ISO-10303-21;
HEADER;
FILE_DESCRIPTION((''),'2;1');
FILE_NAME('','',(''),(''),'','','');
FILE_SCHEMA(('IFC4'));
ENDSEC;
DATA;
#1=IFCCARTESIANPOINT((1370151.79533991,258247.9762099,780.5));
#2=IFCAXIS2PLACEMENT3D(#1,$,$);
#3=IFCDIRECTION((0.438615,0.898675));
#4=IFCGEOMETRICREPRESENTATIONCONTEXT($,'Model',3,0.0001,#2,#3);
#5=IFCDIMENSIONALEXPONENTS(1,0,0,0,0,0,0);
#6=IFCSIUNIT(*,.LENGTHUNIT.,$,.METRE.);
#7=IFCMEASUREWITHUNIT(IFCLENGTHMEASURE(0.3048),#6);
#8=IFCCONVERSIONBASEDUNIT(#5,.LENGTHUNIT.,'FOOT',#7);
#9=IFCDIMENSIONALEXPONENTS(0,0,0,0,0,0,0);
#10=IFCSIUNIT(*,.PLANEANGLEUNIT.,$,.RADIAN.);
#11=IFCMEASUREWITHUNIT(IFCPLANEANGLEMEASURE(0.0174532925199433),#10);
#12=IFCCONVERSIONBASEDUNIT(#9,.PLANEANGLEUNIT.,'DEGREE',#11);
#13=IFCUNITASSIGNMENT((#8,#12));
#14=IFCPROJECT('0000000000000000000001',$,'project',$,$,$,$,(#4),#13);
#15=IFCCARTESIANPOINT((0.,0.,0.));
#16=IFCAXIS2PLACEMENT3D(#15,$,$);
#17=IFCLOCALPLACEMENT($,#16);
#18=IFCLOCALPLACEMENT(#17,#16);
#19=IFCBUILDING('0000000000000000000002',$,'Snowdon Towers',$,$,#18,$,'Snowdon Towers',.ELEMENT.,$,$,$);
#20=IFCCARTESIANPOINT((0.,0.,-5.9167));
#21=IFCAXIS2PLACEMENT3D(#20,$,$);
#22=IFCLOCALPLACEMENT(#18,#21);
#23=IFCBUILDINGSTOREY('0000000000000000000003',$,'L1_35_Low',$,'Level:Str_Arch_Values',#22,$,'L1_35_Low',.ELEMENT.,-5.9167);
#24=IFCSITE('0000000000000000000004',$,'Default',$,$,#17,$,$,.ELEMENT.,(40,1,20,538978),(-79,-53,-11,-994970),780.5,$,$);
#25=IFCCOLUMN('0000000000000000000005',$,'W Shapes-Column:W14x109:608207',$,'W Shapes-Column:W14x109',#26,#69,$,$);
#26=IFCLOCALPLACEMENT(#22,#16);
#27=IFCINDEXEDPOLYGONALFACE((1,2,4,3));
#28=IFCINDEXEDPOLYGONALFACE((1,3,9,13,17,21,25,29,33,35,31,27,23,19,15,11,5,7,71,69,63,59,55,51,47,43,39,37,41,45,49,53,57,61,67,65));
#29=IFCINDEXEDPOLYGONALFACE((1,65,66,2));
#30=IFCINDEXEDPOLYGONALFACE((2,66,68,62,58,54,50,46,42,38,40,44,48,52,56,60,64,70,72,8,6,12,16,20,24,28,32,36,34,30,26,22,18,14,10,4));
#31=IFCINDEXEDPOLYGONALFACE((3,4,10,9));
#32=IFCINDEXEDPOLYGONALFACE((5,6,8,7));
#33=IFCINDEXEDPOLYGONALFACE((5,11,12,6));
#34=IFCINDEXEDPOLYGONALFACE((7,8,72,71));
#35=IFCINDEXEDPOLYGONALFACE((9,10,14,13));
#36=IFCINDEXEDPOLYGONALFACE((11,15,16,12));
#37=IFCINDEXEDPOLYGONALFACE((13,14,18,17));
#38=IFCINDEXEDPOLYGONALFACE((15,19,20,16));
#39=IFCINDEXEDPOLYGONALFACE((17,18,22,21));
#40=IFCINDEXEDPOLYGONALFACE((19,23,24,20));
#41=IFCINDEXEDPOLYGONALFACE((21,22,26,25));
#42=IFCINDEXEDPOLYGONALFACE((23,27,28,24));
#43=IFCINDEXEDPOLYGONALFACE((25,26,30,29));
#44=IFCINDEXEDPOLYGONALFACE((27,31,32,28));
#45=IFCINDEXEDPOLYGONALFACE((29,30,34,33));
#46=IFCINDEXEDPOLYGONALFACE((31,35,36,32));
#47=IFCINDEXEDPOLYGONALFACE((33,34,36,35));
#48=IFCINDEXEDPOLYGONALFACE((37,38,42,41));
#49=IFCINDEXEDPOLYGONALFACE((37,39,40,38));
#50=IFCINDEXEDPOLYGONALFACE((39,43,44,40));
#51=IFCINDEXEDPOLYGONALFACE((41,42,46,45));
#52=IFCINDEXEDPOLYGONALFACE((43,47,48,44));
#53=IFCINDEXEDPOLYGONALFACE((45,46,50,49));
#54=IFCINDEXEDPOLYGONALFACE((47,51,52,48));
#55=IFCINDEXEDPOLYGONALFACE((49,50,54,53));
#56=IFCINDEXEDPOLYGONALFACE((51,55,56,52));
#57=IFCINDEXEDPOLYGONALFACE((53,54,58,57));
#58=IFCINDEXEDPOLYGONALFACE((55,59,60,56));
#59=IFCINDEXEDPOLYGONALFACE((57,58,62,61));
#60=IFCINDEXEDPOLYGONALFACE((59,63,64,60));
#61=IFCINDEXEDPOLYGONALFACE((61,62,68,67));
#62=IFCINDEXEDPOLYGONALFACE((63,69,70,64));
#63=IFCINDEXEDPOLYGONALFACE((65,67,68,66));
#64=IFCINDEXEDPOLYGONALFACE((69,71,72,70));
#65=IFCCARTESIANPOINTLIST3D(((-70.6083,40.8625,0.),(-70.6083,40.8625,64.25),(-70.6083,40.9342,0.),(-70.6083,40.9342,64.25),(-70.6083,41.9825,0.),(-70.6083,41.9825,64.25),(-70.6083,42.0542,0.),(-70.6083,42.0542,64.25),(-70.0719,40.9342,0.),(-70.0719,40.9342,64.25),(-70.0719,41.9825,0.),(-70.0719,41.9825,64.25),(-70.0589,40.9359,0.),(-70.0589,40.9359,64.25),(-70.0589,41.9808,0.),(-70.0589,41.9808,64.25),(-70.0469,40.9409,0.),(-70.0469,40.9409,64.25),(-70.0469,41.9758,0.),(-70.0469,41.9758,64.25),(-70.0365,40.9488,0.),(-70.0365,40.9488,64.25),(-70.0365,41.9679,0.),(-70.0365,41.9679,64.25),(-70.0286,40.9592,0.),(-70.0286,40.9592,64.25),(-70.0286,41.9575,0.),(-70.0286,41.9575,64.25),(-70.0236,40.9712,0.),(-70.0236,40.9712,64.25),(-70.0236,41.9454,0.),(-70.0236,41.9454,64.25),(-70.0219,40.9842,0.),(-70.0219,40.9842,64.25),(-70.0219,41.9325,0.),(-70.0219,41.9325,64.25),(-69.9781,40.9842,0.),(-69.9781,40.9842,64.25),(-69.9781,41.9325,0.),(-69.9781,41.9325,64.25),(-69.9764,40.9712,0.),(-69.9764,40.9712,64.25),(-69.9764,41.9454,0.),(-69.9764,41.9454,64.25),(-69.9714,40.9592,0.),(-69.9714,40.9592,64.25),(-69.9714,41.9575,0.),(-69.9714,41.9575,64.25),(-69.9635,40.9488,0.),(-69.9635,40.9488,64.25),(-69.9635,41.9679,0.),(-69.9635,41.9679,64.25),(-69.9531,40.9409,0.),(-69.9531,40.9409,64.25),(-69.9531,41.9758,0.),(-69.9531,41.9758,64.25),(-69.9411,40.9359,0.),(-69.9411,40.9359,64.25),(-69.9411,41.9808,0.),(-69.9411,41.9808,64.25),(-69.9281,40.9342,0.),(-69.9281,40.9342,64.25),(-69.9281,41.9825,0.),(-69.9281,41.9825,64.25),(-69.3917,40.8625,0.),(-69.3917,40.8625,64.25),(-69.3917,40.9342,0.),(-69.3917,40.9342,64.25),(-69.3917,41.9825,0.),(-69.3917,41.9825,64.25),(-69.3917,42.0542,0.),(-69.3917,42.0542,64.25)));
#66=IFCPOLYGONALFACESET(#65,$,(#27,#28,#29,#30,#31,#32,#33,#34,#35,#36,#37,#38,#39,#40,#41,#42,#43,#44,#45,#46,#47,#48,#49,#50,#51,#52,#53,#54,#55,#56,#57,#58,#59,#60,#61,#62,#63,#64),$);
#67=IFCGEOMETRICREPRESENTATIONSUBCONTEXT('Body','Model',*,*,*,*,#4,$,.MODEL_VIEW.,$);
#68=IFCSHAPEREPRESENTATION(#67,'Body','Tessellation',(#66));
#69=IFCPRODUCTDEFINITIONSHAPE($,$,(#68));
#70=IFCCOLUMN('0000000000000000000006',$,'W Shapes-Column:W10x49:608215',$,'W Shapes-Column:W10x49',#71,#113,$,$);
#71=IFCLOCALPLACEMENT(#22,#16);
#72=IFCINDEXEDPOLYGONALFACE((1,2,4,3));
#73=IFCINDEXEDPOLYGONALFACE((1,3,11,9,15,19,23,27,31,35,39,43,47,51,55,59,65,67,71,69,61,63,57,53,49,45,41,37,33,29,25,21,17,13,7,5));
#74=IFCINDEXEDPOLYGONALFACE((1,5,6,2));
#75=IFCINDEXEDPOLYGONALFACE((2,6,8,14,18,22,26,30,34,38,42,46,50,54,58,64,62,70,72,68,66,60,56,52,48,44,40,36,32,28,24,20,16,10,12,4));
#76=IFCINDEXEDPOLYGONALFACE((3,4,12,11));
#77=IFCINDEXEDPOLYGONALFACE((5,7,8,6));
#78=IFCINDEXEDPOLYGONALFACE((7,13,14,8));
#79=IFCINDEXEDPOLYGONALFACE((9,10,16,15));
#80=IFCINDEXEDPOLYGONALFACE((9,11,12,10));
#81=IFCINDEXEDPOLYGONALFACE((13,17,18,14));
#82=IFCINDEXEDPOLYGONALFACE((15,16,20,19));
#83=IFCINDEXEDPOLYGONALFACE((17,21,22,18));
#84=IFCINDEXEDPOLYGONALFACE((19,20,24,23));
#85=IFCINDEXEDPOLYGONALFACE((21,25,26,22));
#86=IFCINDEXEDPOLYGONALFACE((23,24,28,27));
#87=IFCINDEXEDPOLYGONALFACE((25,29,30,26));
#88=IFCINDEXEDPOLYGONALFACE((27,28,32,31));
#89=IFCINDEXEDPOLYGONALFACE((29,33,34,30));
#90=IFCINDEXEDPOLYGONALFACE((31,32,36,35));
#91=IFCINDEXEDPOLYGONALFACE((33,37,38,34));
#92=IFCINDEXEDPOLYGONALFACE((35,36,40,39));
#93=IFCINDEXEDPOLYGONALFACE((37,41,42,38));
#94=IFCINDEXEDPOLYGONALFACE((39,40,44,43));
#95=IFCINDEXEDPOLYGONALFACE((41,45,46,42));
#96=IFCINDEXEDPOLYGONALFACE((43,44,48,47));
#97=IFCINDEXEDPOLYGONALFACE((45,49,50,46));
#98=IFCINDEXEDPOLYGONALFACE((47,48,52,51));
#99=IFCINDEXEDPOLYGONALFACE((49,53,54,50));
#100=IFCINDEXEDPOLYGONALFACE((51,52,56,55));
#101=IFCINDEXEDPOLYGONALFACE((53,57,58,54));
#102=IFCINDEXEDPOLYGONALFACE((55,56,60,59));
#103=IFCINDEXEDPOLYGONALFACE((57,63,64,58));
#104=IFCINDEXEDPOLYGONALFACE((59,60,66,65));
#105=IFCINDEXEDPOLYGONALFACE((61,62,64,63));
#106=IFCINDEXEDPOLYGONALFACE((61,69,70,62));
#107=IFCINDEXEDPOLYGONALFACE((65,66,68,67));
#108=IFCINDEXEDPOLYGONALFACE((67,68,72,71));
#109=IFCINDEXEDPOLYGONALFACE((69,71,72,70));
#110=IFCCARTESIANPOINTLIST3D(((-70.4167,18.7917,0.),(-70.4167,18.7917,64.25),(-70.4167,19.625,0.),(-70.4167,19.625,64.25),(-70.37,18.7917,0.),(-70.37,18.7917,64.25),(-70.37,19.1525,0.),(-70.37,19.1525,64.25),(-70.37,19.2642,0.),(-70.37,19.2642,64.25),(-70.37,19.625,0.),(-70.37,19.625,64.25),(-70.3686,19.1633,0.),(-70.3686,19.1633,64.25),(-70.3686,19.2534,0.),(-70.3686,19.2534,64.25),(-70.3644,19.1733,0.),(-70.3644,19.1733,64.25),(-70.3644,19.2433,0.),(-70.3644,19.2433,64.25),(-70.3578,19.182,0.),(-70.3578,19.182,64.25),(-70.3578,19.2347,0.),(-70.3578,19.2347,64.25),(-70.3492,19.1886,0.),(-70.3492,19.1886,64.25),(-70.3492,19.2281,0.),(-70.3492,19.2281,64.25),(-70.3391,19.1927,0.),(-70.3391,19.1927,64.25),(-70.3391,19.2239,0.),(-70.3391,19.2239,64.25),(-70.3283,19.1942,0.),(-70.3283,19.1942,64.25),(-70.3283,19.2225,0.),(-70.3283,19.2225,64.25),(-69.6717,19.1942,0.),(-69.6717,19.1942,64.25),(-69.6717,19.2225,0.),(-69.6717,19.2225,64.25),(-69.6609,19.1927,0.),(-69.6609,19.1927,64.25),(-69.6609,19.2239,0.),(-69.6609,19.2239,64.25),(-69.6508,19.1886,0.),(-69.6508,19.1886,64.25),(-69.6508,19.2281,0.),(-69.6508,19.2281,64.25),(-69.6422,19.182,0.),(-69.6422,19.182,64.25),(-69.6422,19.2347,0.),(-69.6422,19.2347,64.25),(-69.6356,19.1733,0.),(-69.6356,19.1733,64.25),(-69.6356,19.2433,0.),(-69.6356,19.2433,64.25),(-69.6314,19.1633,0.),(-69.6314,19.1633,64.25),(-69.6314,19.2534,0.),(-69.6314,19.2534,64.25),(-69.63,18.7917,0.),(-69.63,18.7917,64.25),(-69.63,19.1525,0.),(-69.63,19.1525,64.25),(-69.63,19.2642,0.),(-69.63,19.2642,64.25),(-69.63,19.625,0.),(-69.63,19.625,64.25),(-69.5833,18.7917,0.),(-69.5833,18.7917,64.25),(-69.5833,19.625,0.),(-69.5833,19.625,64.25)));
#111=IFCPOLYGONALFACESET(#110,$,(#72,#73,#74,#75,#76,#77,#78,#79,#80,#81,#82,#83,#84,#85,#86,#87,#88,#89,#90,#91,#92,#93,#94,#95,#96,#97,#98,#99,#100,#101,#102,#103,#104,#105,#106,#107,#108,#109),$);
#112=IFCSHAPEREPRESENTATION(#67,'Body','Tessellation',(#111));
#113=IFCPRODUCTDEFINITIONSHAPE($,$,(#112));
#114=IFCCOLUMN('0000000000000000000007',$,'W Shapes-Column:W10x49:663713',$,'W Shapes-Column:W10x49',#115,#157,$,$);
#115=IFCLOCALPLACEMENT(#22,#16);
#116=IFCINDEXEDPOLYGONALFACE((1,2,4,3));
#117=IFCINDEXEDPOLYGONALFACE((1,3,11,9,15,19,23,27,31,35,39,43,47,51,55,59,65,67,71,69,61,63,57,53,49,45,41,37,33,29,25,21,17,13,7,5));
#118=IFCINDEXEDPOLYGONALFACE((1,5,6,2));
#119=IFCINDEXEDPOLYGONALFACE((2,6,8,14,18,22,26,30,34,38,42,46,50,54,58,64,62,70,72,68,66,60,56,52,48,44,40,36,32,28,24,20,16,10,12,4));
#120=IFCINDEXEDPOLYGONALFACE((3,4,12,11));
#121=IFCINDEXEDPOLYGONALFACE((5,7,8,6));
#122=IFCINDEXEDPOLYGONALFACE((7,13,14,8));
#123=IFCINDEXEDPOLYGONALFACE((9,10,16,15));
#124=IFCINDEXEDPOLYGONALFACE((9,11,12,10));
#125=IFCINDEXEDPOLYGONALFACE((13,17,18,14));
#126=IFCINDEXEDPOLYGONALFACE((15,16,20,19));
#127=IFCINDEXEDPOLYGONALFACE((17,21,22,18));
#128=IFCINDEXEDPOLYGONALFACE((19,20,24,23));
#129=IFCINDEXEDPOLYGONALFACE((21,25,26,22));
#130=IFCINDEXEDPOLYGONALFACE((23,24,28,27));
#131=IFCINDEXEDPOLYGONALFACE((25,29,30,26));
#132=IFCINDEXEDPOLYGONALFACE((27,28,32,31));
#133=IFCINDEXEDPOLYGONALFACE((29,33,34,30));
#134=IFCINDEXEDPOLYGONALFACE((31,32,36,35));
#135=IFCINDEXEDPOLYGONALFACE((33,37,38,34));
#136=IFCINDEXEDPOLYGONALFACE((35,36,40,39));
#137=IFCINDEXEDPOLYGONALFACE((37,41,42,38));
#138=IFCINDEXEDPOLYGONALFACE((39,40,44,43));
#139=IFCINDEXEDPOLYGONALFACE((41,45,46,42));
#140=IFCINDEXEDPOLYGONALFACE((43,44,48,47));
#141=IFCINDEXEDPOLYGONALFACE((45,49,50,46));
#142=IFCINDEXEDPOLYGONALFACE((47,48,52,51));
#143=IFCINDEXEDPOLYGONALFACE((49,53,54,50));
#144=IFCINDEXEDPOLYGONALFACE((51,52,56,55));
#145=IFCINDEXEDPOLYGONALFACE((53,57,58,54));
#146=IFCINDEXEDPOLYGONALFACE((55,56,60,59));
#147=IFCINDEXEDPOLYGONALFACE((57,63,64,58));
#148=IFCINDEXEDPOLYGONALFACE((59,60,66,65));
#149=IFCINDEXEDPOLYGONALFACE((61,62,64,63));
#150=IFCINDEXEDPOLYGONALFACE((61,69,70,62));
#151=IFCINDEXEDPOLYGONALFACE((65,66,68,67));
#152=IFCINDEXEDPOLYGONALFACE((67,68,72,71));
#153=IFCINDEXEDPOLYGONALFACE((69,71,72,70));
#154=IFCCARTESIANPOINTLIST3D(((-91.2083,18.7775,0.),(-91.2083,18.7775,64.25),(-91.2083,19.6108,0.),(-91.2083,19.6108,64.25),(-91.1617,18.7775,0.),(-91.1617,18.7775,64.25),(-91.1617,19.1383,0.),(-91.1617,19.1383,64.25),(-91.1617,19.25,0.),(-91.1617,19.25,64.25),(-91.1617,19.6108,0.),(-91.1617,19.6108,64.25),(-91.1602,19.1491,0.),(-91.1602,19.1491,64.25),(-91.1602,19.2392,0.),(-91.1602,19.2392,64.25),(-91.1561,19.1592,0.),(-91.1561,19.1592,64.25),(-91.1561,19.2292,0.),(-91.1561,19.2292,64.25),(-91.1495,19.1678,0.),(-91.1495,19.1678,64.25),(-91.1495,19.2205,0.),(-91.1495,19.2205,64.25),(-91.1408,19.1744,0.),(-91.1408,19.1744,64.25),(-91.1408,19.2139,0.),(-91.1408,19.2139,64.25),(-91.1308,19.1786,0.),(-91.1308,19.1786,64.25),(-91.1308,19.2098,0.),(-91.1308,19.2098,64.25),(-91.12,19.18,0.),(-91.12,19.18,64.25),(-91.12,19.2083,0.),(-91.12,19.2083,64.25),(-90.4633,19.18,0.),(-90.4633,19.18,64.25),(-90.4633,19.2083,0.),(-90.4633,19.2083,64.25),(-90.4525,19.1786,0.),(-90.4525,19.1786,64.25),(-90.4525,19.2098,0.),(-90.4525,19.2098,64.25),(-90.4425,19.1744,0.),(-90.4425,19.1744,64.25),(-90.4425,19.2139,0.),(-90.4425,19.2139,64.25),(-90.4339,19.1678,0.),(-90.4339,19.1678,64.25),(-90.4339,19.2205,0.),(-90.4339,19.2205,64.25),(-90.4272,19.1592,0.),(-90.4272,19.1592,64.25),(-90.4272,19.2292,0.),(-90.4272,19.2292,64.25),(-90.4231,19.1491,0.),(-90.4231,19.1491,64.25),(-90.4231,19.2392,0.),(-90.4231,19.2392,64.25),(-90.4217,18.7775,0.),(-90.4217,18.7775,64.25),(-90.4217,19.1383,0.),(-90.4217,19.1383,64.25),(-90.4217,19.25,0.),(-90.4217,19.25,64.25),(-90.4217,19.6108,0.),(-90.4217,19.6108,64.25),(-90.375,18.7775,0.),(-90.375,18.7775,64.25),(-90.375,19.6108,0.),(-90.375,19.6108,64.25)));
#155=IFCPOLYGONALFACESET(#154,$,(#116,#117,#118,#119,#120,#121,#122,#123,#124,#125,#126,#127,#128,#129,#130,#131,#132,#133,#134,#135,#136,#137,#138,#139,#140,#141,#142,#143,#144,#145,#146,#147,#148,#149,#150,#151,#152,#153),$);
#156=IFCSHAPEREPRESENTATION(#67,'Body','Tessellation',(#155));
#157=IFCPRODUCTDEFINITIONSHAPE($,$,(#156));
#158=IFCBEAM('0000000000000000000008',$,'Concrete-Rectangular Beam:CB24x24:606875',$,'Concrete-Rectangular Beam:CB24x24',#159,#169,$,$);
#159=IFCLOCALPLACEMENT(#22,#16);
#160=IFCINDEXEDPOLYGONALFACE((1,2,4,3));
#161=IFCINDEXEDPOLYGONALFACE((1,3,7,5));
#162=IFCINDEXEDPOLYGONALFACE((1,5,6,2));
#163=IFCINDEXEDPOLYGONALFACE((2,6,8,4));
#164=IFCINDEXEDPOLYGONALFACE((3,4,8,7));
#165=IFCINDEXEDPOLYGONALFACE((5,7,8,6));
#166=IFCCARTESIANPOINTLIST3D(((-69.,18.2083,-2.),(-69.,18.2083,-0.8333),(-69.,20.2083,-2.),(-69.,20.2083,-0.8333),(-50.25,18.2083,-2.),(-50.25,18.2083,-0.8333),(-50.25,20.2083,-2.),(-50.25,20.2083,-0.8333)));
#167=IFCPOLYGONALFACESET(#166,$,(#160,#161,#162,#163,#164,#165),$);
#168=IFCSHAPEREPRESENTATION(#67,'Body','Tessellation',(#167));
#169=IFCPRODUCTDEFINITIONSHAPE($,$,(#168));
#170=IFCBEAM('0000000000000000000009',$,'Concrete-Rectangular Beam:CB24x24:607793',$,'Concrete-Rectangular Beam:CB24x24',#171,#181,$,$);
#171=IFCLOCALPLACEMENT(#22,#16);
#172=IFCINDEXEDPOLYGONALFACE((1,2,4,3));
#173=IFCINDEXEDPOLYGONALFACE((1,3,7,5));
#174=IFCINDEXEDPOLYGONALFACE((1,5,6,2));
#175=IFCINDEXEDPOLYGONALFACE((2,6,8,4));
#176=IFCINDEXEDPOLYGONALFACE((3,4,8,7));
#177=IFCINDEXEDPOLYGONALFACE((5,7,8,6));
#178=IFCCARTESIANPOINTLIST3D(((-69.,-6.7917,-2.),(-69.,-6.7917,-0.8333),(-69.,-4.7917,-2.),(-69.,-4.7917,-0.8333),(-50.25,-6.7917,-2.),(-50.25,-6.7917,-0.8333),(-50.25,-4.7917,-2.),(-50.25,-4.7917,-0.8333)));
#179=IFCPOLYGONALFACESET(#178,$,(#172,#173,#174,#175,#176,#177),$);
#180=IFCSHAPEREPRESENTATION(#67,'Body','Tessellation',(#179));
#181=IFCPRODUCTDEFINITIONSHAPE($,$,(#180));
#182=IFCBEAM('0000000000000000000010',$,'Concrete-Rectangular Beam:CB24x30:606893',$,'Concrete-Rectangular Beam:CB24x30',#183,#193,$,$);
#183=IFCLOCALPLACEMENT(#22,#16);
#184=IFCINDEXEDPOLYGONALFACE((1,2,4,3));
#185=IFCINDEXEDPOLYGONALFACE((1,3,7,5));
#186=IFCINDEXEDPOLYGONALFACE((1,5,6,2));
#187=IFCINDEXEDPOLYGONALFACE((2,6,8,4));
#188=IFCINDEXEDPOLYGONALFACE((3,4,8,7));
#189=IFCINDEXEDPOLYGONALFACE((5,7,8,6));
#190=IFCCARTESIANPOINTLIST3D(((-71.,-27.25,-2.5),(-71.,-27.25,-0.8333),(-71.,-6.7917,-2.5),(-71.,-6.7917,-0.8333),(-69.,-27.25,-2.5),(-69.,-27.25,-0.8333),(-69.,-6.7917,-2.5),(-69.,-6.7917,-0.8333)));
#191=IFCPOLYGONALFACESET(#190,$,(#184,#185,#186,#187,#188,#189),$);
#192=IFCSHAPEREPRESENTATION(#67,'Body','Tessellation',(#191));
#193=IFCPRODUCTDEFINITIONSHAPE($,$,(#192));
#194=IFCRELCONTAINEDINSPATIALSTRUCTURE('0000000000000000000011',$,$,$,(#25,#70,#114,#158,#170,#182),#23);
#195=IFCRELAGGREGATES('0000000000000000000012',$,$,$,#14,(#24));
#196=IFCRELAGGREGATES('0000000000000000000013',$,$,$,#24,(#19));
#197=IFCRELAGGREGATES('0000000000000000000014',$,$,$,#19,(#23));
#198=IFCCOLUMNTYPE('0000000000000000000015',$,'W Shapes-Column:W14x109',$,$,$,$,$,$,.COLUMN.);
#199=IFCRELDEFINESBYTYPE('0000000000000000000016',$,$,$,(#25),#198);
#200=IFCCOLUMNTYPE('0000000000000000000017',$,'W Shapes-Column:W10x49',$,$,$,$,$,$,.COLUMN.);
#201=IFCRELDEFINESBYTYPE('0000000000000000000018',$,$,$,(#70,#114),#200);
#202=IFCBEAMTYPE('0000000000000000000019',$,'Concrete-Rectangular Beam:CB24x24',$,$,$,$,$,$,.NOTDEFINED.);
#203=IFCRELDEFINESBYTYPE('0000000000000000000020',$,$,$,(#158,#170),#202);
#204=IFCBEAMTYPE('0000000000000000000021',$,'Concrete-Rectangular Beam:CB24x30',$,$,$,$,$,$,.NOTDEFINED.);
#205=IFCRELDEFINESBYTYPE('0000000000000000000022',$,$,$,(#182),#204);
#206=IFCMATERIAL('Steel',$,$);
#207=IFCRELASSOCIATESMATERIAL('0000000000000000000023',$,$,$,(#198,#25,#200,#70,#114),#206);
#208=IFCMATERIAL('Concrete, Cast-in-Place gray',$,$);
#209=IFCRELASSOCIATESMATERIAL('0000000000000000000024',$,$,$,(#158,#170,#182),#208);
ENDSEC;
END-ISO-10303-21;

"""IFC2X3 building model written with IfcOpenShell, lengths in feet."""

from ifc_helpers import new_model, entity, si_unit, converted_unit, direction, frame, frame_2d, origin, place, context, subcontext, project, spatial, rectangle, i_section, extrude, source, transform, mapped, material, type_object, type_shapes, element, save


model = new_model("IFC2X3")

# Units and contexts
model_context = context("Model", 3, precision=0.0001, world=frame((1370151.79533991, 258247.9762099, 780.5)), true_north=direction((0.438615, 0.898675)))
body_context = subcontext(model_context, "Body", "Model", "MODEL_VIEW")
ifc_project = project(units=[converted_unit("LENGTHUNIT", "FOOT", entity("IfcLengthMeasure", 0.3048), si_unit("LENGTHUNIT", "METRE"), dimensions=[1, 0, 0, 0, 0, 0, 0]), converted_unit("PLANEANGLEUNIT", "DEGREE", entity("IfcPlaneAngleMeasure", 0.0174532925199433), si_unit("PLANEANGLEUNIT", "RADIAN"), dimensions=[0, 0, 0, 0, 0, 0, 0])], contexts=[model_context])

# Site, building, storey
site_placement = place(None, origin())
site = spatial("IfcSite", under=ifc_project, at=site_placement, Name="Default", CompositionType="ELEMENT", RefLatitude=(40, 1, 20, 538978), RefLongitude=(-79, -53, -11, -994970), RefElevation=780.5)
building_placement = place(site_placement, origin())
building = spatial("IfcBuilding", under=site, at=building_placement, Name="Snowdon Towers", LongName="Snowdon Towers", CompositionType="ELEMENT")
storey_placement = place(building_placement, frame((0.0, 0.0, -5.9167)))
storey = spatial("IfcBuildingStorey", under=building, at=storey_placement, Name="L1_35_Low", ObjectType="Level:Str_Arch_Values", LongName="L1_35_Low", CompositionType="ELEMENT", Elevation=-5.9167)

# Columns
ifc_material_1 = material(Name="Steel")
column_type_1 = type_object("IfcColumnType", Name="W Shapes-Column:W14x109", PredefinedType="COLUMN", material=ifc_material_1)
shared_shape_1 = source(origin(), body_context, "Body", "SweptSolid", [
    extrude(i_section(OverallWidth=1.2167, OverallDepth=1.1917, WebThickness=0.0438, FlangeThickness=0.0717, FilletRadius=0.05, at=frame_2d((0.0, 0.0), x_axis=(1.0, 0.0))), frame((0.0, 0.0, -5.9167), z_axis=(0.0, 0.0, 1.0), x_axis=(-1.0, 0.0, 0.0)), (0.0, 0.0, 1.0), 64.25),
])
type_shapes(column_type_1, [shared_shape_1])
column_placement = place(storey_placement, frame((-70.0, 41.4583, 5.9167), z_axis=(0.0, 0.0, 1.0), x_axis=(-1.0, 0.0, 0.0)))
element("IfcColumn", 1, at=column_placement, inside=storey, type_object=column_type_1, material=ifc_material_1, Name="W Shapes-Column:W14x109:608207", ObjectType="W Shapes-Column:W14x109", context=body_context, shape_type="MappedRepresentation", body=[
    mapped(shared_shape_1, transform((0.0, 0.0, 0.0), scale=1.0)),
])
column_type_2 = type_object("IfcColumnType", Name="W Shapes-Column:W10x49", PredefinedType="COLUMN", material=ifc_material_1)
shared_shape_2 = source(origin(), body_context, "Body", "SweptSolid", [
    extrude(i_section(OverallWidth=0.8333, OverallDepth=0.8333, WebThickness=0.0283, FlangeThickness=0.0467, FilletRadius=0.0417, at=frame_2d((0.0, 0.0), x_axis=(1.0, 0.0))), frame((0.0, 0.0, -5.9167), z_axis=(0.0, 0.0, 1.0), x_axis=(-1.0, 0.0, 0.0)), (0.0, 0.0, 1.0), 64.25),
])
type_shapes(column_type_2, [shared_shape_2])
for number, where, z_axis, x_axis, name in (
    (2, (-70.0, 19.2083, 5.9167), (0.0, 0.0, 1.0), (0.0, 1.0, 0.0), "W Shapes-Column:W10x49:608215"),
    (3, (-90.7917, 19.1942, 5.9167), (0.0, 0.0, 1.0), (0.0, 1.0, 0.0), "W Shapes-Column:W10x49:663713"),
):
    element("IfcColumn", number, at=place(storey_placement, frame(where, z_axis=z_axis, x_axis=x_axis)), inside=storey, type_object=column_type_2, material=ifc_material_1, Name=name, ObjectType="W Shapes-Column:W10x49", context=body_context, shape_type="MappedRepresentation", body=[
        mapped(shared_shape_2, transform((0.0, 0.0, 0.0), scale=1.0)),
    ])

# Beams
ifc_material_2 = material(Name="Concrete, Cast-in-Place gray")
beam_type_1 = type_object("IfcBeamType", Name="Concrete-Rectangular Beam:CB24x24", PredefinedType="NOTDEFINED")
beam_1_placement = place(storey_placement, frame((-70.0, 19.2083, 0.0)))
element("IfcBeam", 4, at=beam_1_placement, inside=storey, type_object=beam_type_1, material=ifc_material_2, Name="Concrete-Rectangular Beam:CB24x24:606875", ObjectType="Concrete-Rectangular Beam:CB24x24", context=body_context, shape_type="SweptSolid", body=[
    extrude(rectangle(XDim=1.1667, YDim=2.0, at=frame_2d((0.0, 0.0), x_axis=(1.0, 0.0))), frame((1.0, 0.0, -1.4167), z_axis=(1.0, 0.0, 0.0), x_axis=(0.0, 0.0, -1.0)), (0.0, 0.0, 1.0), 18.75),
])
beam_2_placement = place(storey_placement, frame((-70.0, -5.7917, 0.0)))
element("IfcBeam", 5, at=beam_2_placement, inside=storey, type_object=beam_type_1, material=ifc_material_2, Name="Concrete-Rectangular Beam:CB24x24:607793", ObjectType="Concrete-Rectangular Beam:CB24x24", context=body_context, shape_type="SweptSolid", body=[
    extrude(rectangle(XDim=1.1667, YDim=2.0, at=frame_2d((0.0, 0.0), x_axis=(1.0, 0.0))), frame((1.0, 0.0, -1.4167), z_axis=(1.0, 0.0, 0.0), x_axis=(0.0, 0.0, -1.0)), (0.0, 0.0, 1.0), 18.75),
])
beam_type_2 = type_object("IfcBeamType", Name="Concrete-Rectangular Beam:CB24x30", PredefinedType="NOTDEFINED")
beam_3_placement = place(storey_placement, frame((-70.0, -28.25, 0.0), z_axis=(0.0, 0.0, 1.0), x_axis=(0.0, 1.0, 0.0)))
element("IfcBeam", 6, at=beam_3_placement, inside=storey, type_object=beam_type_2, material=ifc_material_2, Name="Concrete-Rectangular Beam:CB24x30:606893", ObjectType="Concrete-Rectangular Beam:CB24x30", context=body_context, shape_type="SweptSolid", body=[
    extrude(rectangle(XDim=1.6667, YDim=2.0, at=frame_2d((0.0, 0.0), x_axis=(1.0, 0.0))), frame((1.0, 0.0, -1.6667), z_axis=(1.0, 0.0, 0.0), x_axis=(0.0, 0.0, -1.0)), (0.0, 0.0, 1.0), 20.4583),
])

save(model, "model.ifc")
